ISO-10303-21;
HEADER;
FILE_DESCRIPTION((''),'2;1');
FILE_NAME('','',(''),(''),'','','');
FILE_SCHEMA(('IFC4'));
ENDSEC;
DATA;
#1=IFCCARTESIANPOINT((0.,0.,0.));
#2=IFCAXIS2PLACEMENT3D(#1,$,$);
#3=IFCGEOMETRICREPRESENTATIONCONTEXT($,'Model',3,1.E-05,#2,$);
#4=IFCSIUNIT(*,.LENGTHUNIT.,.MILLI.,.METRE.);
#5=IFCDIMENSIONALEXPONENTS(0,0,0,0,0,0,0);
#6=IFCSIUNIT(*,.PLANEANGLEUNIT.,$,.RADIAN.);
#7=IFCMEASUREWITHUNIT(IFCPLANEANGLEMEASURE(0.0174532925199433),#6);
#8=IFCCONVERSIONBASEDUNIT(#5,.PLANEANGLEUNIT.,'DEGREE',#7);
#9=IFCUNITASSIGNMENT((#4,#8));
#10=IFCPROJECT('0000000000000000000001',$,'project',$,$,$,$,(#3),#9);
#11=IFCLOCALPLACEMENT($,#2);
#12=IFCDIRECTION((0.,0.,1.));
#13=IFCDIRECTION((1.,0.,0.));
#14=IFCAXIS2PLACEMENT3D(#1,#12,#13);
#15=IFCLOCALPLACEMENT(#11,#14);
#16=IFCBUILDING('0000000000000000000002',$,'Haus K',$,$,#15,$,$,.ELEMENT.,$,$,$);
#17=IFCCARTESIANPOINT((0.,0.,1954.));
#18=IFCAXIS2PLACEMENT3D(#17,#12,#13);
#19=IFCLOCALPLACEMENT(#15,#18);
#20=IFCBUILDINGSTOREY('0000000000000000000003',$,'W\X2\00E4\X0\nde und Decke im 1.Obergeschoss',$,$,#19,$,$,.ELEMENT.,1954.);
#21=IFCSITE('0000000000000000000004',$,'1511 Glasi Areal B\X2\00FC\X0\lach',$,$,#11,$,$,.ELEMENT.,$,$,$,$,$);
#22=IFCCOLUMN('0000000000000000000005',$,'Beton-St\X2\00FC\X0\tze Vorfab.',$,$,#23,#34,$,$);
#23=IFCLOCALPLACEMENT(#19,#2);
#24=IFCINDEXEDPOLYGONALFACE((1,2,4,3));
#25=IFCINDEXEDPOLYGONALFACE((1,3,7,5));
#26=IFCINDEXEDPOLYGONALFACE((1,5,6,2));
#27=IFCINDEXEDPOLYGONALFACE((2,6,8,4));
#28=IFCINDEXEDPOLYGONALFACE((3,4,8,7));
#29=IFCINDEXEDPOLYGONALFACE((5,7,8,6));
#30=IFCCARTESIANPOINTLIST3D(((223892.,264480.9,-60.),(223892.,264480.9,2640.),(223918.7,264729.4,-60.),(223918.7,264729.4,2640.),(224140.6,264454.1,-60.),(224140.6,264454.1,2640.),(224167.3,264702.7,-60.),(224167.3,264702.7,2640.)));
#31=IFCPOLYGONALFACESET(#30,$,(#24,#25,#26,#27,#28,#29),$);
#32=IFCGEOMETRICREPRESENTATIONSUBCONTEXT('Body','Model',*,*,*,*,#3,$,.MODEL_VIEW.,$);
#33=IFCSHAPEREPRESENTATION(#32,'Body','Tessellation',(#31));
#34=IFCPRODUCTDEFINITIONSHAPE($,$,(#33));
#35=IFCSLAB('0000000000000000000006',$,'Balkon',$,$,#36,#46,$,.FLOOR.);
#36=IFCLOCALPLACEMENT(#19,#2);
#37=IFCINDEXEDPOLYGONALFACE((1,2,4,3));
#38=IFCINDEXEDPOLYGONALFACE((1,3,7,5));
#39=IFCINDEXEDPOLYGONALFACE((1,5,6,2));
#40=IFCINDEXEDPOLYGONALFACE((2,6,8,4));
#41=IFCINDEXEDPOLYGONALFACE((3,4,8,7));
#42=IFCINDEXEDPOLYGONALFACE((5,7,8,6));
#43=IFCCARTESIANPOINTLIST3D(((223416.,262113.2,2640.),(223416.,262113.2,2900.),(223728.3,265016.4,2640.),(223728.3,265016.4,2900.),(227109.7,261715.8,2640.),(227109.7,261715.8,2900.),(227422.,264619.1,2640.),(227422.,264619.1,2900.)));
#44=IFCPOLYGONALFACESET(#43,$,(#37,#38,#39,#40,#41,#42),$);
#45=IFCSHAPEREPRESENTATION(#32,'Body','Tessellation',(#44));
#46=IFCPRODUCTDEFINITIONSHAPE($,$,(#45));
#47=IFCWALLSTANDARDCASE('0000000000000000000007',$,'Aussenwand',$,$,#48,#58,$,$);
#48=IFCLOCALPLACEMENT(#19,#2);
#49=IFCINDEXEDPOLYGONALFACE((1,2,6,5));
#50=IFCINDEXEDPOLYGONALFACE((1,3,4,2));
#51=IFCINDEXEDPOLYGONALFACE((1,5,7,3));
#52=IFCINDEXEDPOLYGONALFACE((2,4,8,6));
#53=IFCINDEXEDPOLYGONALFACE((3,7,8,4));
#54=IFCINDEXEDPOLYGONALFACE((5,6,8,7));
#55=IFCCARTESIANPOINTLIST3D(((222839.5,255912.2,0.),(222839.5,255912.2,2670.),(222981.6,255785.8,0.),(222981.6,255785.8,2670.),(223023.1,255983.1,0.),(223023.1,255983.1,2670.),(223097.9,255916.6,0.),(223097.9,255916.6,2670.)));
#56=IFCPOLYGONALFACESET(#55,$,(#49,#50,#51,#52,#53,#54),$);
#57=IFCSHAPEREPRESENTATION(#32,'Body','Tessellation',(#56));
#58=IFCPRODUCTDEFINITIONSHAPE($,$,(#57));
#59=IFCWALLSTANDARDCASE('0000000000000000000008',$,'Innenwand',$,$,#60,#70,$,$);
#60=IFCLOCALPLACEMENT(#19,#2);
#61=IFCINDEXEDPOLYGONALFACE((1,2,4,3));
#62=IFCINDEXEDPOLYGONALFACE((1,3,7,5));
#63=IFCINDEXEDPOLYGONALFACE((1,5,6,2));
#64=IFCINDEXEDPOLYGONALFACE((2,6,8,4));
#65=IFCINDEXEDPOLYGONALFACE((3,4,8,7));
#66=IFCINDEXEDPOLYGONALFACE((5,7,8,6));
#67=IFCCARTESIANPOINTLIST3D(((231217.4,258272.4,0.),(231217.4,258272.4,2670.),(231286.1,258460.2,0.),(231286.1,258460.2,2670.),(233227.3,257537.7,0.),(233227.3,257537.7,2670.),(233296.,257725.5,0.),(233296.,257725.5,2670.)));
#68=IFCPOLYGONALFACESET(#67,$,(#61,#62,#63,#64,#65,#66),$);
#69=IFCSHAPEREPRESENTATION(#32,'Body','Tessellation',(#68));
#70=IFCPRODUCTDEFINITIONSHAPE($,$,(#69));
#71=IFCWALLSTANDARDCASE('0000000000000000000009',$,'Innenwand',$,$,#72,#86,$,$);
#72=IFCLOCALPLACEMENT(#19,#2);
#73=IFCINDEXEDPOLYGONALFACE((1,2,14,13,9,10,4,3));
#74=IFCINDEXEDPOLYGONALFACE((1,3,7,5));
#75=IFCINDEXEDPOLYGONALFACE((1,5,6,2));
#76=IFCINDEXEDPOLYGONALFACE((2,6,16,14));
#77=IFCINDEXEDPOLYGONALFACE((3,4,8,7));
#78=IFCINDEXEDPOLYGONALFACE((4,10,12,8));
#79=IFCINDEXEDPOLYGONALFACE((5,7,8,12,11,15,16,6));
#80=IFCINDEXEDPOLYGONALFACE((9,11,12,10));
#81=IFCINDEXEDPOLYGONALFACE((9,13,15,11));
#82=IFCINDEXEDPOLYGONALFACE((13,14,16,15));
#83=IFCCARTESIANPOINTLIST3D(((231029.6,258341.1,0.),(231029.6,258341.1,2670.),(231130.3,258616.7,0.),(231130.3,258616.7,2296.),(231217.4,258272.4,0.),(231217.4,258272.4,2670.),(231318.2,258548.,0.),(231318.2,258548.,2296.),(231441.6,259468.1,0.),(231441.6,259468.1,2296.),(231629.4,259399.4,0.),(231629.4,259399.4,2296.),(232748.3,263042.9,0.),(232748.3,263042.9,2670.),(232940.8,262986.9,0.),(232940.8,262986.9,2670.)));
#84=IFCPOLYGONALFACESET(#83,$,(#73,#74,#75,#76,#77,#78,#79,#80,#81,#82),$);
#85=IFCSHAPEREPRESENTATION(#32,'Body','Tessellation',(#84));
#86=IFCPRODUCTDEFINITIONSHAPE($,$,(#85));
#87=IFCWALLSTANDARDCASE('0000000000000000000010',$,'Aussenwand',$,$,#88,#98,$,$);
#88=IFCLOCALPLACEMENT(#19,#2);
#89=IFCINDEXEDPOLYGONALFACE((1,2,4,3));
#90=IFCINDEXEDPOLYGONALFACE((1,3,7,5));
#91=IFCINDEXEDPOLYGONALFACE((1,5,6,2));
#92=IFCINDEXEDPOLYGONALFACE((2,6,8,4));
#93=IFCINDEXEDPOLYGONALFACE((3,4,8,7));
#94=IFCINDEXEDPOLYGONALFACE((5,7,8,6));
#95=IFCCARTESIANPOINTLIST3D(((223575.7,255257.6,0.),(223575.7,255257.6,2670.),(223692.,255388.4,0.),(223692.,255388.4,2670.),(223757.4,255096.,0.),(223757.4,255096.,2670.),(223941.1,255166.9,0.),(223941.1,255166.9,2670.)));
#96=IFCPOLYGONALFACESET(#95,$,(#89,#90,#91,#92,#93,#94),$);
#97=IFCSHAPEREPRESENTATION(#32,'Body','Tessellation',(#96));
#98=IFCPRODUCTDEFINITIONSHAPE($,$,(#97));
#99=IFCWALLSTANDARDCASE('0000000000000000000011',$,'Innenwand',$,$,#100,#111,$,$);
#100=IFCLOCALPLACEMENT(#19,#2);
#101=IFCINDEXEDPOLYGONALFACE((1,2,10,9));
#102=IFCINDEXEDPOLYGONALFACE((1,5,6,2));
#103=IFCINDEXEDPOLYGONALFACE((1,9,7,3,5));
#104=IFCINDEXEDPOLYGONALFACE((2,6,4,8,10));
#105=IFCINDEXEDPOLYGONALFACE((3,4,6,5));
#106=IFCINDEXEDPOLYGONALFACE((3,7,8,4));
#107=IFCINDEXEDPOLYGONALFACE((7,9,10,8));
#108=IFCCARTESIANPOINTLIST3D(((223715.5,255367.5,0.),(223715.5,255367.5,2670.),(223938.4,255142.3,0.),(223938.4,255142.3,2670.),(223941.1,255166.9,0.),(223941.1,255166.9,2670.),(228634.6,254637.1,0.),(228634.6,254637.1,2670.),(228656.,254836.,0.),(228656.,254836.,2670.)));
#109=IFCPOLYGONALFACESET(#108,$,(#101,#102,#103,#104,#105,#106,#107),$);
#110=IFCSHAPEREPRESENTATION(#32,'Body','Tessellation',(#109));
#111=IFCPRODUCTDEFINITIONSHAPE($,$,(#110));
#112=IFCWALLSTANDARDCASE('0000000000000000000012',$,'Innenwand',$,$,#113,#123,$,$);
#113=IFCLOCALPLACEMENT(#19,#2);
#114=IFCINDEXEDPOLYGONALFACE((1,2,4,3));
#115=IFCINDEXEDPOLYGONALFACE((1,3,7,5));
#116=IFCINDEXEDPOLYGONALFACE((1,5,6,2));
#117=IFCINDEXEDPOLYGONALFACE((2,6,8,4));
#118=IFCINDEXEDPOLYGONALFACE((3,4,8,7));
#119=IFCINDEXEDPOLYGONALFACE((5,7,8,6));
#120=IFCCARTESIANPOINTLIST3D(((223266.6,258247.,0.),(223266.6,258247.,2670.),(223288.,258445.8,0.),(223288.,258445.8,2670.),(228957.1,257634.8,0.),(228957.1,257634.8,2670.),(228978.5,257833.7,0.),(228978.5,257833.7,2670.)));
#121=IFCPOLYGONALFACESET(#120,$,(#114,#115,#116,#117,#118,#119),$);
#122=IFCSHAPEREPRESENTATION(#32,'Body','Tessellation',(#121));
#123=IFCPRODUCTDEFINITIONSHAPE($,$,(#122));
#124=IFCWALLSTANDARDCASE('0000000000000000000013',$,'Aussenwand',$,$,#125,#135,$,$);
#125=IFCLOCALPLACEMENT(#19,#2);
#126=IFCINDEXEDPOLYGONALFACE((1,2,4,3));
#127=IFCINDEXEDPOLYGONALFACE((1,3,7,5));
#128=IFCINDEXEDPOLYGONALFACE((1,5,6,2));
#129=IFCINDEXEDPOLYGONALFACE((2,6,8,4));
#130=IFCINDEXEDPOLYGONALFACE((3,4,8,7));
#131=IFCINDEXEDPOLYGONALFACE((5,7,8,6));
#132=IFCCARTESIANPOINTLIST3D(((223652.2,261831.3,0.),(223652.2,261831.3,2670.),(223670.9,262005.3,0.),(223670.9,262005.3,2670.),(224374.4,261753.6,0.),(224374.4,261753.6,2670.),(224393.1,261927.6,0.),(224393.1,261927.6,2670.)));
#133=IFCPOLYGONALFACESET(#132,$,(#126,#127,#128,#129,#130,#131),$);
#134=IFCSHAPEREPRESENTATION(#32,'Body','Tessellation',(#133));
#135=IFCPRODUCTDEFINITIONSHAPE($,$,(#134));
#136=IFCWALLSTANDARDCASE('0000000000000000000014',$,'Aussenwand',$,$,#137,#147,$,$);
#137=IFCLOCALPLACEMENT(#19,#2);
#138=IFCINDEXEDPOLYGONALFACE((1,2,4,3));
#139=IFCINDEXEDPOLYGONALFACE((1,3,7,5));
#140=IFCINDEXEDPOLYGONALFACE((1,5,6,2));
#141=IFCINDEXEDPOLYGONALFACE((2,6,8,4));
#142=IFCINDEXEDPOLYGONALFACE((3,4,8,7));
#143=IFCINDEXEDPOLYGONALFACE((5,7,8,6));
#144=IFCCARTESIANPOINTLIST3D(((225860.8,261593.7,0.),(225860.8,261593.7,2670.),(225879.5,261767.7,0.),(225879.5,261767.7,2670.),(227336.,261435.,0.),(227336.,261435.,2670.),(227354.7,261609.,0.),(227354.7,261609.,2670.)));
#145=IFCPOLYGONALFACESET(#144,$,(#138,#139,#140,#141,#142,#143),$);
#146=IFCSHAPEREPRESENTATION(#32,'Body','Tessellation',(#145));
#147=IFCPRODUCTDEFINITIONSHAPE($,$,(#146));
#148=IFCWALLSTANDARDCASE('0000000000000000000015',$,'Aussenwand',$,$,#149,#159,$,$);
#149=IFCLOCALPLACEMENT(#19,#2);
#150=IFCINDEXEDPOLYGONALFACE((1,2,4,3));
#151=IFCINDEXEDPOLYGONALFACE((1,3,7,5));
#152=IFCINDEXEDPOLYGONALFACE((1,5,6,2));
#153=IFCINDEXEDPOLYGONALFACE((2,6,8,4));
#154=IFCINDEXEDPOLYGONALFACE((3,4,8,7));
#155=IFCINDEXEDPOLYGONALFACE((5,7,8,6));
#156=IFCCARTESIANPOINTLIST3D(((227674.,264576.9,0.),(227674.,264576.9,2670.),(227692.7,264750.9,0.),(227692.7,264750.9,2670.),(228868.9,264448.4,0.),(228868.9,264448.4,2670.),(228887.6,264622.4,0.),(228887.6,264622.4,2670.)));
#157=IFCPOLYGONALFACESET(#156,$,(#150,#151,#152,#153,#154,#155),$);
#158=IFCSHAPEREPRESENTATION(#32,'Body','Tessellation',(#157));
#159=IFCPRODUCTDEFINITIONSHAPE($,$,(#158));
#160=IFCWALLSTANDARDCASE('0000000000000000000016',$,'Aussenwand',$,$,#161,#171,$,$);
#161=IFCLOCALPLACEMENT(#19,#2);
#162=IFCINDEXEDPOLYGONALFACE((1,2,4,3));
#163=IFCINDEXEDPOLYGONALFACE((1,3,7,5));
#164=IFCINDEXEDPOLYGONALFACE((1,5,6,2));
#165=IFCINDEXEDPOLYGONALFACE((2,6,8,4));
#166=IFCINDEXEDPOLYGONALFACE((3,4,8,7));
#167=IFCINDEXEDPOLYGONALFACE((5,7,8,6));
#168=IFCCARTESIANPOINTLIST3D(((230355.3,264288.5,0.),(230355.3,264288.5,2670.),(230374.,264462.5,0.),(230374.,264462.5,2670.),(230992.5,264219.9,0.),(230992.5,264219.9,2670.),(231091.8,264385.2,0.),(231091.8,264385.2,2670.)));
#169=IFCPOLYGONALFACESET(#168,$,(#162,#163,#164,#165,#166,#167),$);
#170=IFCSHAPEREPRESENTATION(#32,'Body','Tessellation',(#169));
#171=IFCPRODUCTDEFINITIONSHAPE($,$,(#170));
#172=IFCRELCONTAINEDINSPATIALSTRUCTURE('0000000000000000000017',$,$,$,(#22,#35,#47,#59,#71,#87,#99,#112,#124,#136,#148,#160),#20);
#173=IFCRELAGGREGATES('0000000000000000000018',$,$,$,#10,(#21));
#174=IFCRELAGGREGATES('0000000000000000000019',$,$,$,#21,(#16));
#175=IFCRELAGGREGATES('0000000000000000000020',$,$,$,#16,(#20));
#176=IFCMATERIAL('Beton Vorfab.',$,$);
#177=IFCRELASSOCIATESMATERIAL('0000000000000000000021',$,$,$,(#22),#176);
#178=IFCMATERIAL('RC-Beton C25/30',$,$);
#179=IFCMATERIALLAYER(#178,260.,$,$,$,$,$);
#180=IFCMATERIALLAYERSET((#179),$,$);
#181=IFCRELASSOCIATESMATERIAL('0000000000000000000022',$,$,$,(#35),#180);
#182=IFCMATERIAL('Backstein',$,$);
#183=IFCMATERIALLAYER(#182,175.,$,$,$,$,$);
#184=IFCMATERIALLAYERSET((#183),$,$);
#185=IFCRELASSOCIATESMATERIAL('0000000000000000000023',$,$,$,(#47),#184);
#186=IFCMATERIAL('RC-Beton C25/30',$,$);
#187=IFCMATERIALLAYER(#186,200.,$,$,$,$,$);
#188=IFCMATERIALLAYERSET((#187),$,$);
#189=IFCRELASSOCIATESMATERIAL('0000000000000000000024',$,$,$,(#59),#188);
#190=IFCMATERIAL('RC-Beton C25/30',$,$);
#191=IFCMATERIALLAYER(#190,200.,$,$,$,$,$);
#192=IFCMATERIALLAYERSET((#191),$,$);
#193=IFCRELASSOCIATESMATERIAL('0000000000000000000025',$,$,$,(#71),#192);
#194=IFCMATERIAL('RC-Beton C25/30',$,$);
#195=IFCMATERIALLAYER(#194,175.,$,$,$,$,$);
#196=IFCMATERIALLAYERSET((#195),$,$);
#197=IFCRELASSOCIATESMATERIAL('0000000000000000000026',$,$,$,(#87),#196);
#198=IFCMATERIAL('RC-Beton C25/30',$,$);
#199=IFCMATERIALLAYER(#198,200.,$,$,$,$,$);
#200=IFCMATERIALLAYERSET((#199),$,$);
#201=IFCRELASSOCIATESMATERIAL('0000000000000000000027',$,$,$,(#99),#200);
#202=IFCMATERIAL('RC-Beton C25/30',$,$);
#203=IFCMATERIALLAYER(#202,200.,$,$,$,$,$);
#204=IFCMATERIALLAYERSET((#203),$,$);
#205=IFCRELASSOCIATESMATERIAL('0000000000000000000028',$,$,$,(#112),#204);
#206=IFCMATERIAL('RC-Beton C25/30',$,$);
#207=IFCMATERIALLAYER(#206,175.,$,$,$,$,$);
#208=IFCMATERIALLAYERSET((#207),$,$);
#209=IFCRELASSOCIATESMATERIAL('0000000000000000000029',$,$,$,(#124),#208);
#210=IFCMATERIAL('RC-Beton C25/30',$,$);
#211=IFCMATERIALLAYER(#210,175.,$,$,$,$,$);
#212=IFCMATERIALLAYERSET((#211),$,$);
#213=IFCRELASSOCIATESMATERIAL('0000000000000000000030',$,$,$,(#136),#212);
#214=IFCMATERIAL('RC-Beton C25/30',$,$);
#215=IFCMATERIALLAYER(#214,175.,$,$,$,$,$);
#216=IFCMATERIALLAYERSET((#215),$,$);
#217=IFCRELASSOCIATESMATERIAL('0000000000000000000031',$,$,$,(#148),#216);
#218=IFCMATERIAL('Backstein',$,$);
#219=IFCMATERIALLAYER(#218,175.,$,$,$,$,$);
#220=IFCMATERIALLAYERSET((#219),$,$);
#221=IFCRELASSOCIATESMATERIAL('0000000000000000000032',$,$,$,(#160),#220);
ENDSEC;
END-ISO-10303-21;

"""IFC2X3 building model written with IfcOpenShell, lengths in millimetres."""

from ifc_helpers import new_model, entity, si_unit, converted_unit, frame, frame_2d, origin, origin_with_axes, place, context, subcontext, project, spatial, polyline, rectangle, outline, extrude, material, layer, layer_set, layer_usage, element, save


model = new_model("IFC2X3")

# Units and contexts
model_context = context("Model", 3, precision=1e-05, world=origin())
body_context = subcontext(model_context, "Body", "Model", "MODEL_VIEW")
ifc_project = project(units=[si_unit("LENGTHUNIT", "METRE", prefix="MILLI"), converted_unit("PLANEANGLEUNIT", "DEGREE", entity("IfcPlaneAngleMeasure", 0.0174532925199433), si_unit("PLANEANGLEUNIT", "RADIAN"), dimensions=[0, 0, 0, 0, 0, 0, 0])], contexts=[model_context])

# Site, building, storey
site_placement = place(None, origin())
site = spatial("IfcSite", under=ifc_project, at=site_placement, Name="1511 Glasi Areal Bülach", CompositionType="ELEMENT")
building_placement = place(site_placement, origin_with_axes())
building = spatial("IfcBuilding", under=site, at=building_placement, Name="Haus K", CompositionType="ELEMENT")
storey_placement = place(building_placement, frame((0.0, 0.0, 1954.0), z_axis=(0.0, 0.0, 1.0), x_axis=(1.0, 0.0, 0.0)))
storey = spatial("IfcBuildingStorey", under=building, at=storey_placement, Name="Wände und Decke im 1.Obergeschoss", CompositionType="ELEMENT", Elevation=1954.0)

# Column
ifc_material_1 = material(Name="Beton Vorfab.")
column_placement = place(storey_placement, frame((223892.0, 264480.9, -60.0), z_axis=(0.0, 0.0, 1.0), x_axis=(1.0, 0.0, 0.0)))
element("IfcColumn", 1, at=column_placement, inside=storey, material=ifc_material_1, Name="Beton-Stütze Vorfab.", context=body_context, shape_type="SweptSolid", body=[
    extrude(rectangle(XDim=250.0, YDim=250.0, at=frame_2d((137.7, 110.9), x_axis=(0.994264, -0.106958))), origin_with_axes(), (0.0, 0.0, 1.0), 2700.0),
])

# Slab
ifc_material_2 = material(Name="RC-Beton C25/30")
ifc_layer_1 = layer(ifc_material_2, 260.0)
ifc_layer_set_1 = layer_set([ifc_layer_1])
ifc_layer_usage_1 = layer_usage(ifc_layer_set_1, "AXIS3", "POSITIVE", 0.0)
slab_placement = place(storey_placement, frame((223728.3, 265016.4, 2640.0), z_axis=(0.0, 0.0, 1.0), x_axis=(1.0, 0.0, 0.0)))
element("IfcSlab", 2, at=slab_placement, inside=storey, material=ifc_layer_usage_1, Name="Balkon", PredefinedType="FLOOR", context=body_context, shape_type="SweptSolid", body=[
    extrude(rectangle(XDim=2920.0, YDim=3715.0, at=frame_2d((1690.7, -1650.3), x_axis=(-0.106958, -0.994264))), origin_with_axes(), (0.0, 0.0, 1.0), 260.0),
])

# Walls
ifc_material_3 = material(Name="Backstein")
ifc_layer_2 = layer(ifc_material_3, 175.0)
ifc_layer_set_2 = layer_set([ifc_layer_2])
ifc_layer_usage_2 = layer_usage(ifc_layer_set_2, "AXIS2", "POSITIVE", 0.0)
wall_1_placement = place(storey_placement, frame((222839.5, 255912.2, 0.0), z_axis=(0.0, 0.0, 1.0), x_axis=(0.747334, -0.664448, 0.0)))
element("IfcWallStandardCase", 3, at=wall_1_placement, inside=storey, material=ifc_layer_usage_2, Name="Aussenwand", context=body_context, shape_type="SweptSolid", body=[
    extrude(outline(polyline([(0.0, 0.0), (190.2, 0.0), (190.2, 175.0), (90.1, 175.0), (0.0, 0.0)])), origin_with_axes(), (0.0, 0.0, 1.0), 2670.0),
])
ifc_material_4 = material(Name="RC-Beton C25/30")
ifc_layer_3 = layer(ifc_material_4, 200.0)
ifc_layer_set_3 = layer_set([ifc_layer_3])
ifc_layer_usage_3 = layer_usage(ifc_layer_set_3, "AXIS2", "POSITIVE", 0.0)
wall_2_placement = place(storey_placement, frame((233296.0, 257725.5, 0.0), z_axis=(0.0, 0.0, 1.0), x_axis=(-0.939214, 0.343332, 0.0)))
element("IfcWallStandardCase", 4, at=wall_2_placement, inside=storey, material=ifc_layer_usage_3, Name="Innenwand", context=body_context, shape_type="SweptSolid", body=[
    extrude(rectangle(XDim=2140.0, YDim=200.0, at=frame_2d((1070.0, 100.0), x_axis=(1.0, 0.0))), origin_with_axes(), (0.0, 0.0, 1.0), 2670.0),
])

# Wall, opening
ifc_material_5 = material(Name="RC-Beton C25/30")
ifc_layer_4 = layer(ifc_material_5, 200.0)
ifc_layer_set_4 = layer_set([ifc_layer_4])
ifc_layer_usage_4 = layer_usage(ifc_layer_set_4, "AXIS2", "POSITIVE", 0.0)
wall_3_placement = place(storey_placement, frame((232748.3, 263042.9, 0.0), z_axis=(0.0, 0.0, 1.0), x_axis=(-0.343332, -0.939214, 0.0)))
wall_3 = element("IfcWallStandardCase", 5, at=wall_3_placement, inside=storey, material=ifc_layer_usage_4, Name="Innenwand", context=body_context, shape_type="SweptSolid", body=[
    extrude(outline(polyline([(0.0, 0.0), (5006.2, 0.0), (5006.2, 200.0), (-13.4, 200.0), (0.0, 0.0)])), origin_with_axes(), (0.0, 0.0, 1.0), 2670.0),
])
opening_1_placement = place(wall_3_placement, frame((3806.2, 0.0, 0.0), z_axis=(0.0, 1.0, 0.0), x_axis=(0.0, 0.0, 1.0)))
element("IfcOpeningElement", 6, at=opening_1_placement, cuts=wall_3, ObjectType="Opening", context=body_context, shape_type="SweptSolid", body=[
    extrude(rectangle(XDim=2296.0, YDim=906.5, at=frame_2d((1148.0, 453.3), x_axis=(1.0, 0.0))), origin_with_axes(), (0.0, 0.0, 1.0), 200.0),
])

# Walls
ifc_material_6 = material(Name="RC-Beton C25/30")
ifc_layer_5 = layer(ifc_material_6, 175.0)
ifc_layer_set_5 = layer_set([ifc_layer_5])
ifc_layer_usage_5 = layer_usage(ifc_layer_set_5, "AXIS2", "POSITIVE", 0.0)
wall_4_placement = place(storey_placement, frame((223575.7, 255257.6, 0.0), z_axis=(0.0, 0.0, 1.0), x_axis=(0.747334, -0.664448, 0.0)))
element("IfcWallStandardCase", 7, at=wall_4_placement, inside=storey, material=ifc_layer_usage_5, Name="Aussenwand", context=body_context, shape_type="SweptSolid", body=[
    extrude(outline(polyline([(0.0, 0.0), (243.1, 0.0), (333.3, 175.0), (0.0, 175.0), (0.0, 0.0)])), origin_with_axes(), (0.0, 0.0, 1.0), 2670.0),
])
ifc_material_7 = material(Name="RC-Beton C25/30")
ifc_layer_6 = layer(ifc_material_7, 200.0)
ifc_layer_set_6 = layer_set([ifc_layer_6])
ifc_layer_usage_6 = layer_usage(ifc_layer_set_6, "AXIS2", "POSITIVE", 0.0)
wall_5_placement = place(storey_placement, frame((228656.0, 254836.0, 0.0), z_axis=(0.0, 0.0, 1.0), x_axis=(-0.994264, 0.106958, 0.0)))
element("IfcWallStandardCase", 8, at=wall_5_placement, inside=storey, material=ifc_layer_usage_6, Name="Innenwand", context=body_context, shape_type="SweptSolid", body=[
    extrude(outline(polyline([(0.0, 0.0), (4968.9, 0.0), (4723.3, 175.2), (4723.3, 200.0), (0.0, 200.0), (0.0, 0.0)])), origin_with_axes(), (0.0, 0.0, 1.0), 2670.0),
])
ifc_material_8 = material(Name="RC-Beton C25/30")
ifc_layer_7 = layer(ifc_material_8, 200.0)
ifc_layer_set_7 = layer_set([ifc_layer_7])
ifc_layer_usage_7 = layer_usage(ifc_layer_set_7, "AXIS2", "POSITIVE", 0.0)
wall_6_placement = place(storey_placement, frame((223266.6, 258247.0, 0.0), z_axis=(0.0, 0.0, 1.0), x_axis=(0.994264, -0.106958, 0.0)))
element("IfcWallStandardCase", 9, at=wall_6_placement, inside=storey, material=ifc_layer_usage_7, Name="Innenwand", context=body_context, shape_type="SweptSolid", body=[
    extrude(rectangle(XDim=5723.3, YDim=200.0, at=frame_2d((2861.6, 100.0), x_axis=(1.0, 0.0))), origin_with_axes(), (0.0, 0.0, 1.0), 2670.0),
])
ifc_material_9 = material(Name="RC-Beton C25/30")
ifc_layer_8 = layer(ifc_material_9, 175.0)
ifc_layer_set_8 = layer_set([ifc_layer_8])
ifc_layer_usage_8 = layer_usage(ifc_layer_set_8, "AXIS2", "POSITIVE", 0.0)
wall_7_placement = place(storey_placement, frame((224393.1, 261927.6, 0.0), z_axis=(0.0, 0.0, 1.0), x_axis=(-0.994264, 0.106958, 0.0)))
element("IfcWallStandardCase", 10, at=wall_7_placement, inside=storey, material=ifc_layer_usage_8, Name="Aussenwand", context=body_context, shape_type="SweptSolid", body=[
    extrude(rectangle(XDim=726.3, YDim=175.0, at=frame_2d((363.1, 87.5), x_axis=(1.0, 0.0))), origin_with_axes(), (0.0, 0.0, 1.0), 2670.0),
])
ifc_material_10 = material(Name="RC-Beton C25/30")
ifc_layer_9 = layer(ifc_material_10, 175.0)
ifc_layer_set_9 = layer_set([ifc_layer_9])
ifc_layer_usage_9 = layer_usage(ifc_layer_set_9, "AXIS2", "POSITIVE", 0.0)
wall_8_placement = place(storey_placement, frame((227354.7, 261609.0, 0.0), z_axis=(0.0, 0.0, 1.0), x_axis=(-0.994264, 0.106958, 0.0)))
element("IfcWallStandardCase", 11, at=wall_8_placement, inside=storey, material=ifc_layer_usage_9, Name="Aussenwand", context=body_context, shape_type="SweptSolid", body=[
    extrude(rectangle(XDim=1483.7, YDim=175.0, at=frame_2d((741.9, 87.5), x_axis=(1.0, 0.0))), origin_with_axes(), (0.0, 0.0, 1.0), 2670.0),
])
ifc_material_11 = material(Name="RC-Beton C25/30")
ifc_layer_10 = layer(ifc_material_11, 175.0)
ifc_layer_set_10 = layer_set([ifc_layer_10])
ifc_layer_usage_10 = layer_usage(ifc_layer_set_10, "AXIS2", "POSITIVE", 0.0)
wall_9_placement = place(storey_placement, frame((228887.6, 264622.4, 0.0), z_axis=(0.0, 0.0, 1.0), x_axis=(-0.994264, 0.106958, 0.0)))
element("IfcWallStandardCase", 12, at=wall_9_placement, inside=storey, material=ifc_layer_usage_10, Name="Aussenwand", context=body_context, shape_type="SweptSolid", body=[
    extrude(rectangle(XDim=1201.8, YDim=175.0, at=frame_2d((600.9, 87.5), x_axis=(1.0, 0.0))), origin_with_axes(), (0.0, 0.0, 1.0), 2670.0),
])
ifc_material_12 = material(Name="Backstein")
ifc_layer_11 = layer(ifc_material_12, 175.0)
ifc_layer_set_11 = layer_set([ifc_layer_11])
ifc_layer_usage_11 = layer_usage(ifc_layer_set_11, "AXIS2", "POSITIVE", 0.0)
wall_10_placement = place(storey_placement, frame((231091.8, 264385.2, 0.0), z_axis=(0.0, 0.0, 1.0), x_axis=(-0.994264, 0.106958, 0.0)))
element("IfcWallStandardCase", 13, at=wall_10_placement, inside=storey, material=ifc_layer_usage_11, Name="Aussenwand", context=body_context, shape_type="SweptSolid", body=[
    extrude(outline(polyline([(0.0, 0.0), (721.9, 0.0), (721.9, 175.0), (81.1, 175.0), (0.0, 0.0)])), origin_with_axes(), (0.0, 0.0, 1.0), 2670.0),
])

save(model, "model.ifc")
